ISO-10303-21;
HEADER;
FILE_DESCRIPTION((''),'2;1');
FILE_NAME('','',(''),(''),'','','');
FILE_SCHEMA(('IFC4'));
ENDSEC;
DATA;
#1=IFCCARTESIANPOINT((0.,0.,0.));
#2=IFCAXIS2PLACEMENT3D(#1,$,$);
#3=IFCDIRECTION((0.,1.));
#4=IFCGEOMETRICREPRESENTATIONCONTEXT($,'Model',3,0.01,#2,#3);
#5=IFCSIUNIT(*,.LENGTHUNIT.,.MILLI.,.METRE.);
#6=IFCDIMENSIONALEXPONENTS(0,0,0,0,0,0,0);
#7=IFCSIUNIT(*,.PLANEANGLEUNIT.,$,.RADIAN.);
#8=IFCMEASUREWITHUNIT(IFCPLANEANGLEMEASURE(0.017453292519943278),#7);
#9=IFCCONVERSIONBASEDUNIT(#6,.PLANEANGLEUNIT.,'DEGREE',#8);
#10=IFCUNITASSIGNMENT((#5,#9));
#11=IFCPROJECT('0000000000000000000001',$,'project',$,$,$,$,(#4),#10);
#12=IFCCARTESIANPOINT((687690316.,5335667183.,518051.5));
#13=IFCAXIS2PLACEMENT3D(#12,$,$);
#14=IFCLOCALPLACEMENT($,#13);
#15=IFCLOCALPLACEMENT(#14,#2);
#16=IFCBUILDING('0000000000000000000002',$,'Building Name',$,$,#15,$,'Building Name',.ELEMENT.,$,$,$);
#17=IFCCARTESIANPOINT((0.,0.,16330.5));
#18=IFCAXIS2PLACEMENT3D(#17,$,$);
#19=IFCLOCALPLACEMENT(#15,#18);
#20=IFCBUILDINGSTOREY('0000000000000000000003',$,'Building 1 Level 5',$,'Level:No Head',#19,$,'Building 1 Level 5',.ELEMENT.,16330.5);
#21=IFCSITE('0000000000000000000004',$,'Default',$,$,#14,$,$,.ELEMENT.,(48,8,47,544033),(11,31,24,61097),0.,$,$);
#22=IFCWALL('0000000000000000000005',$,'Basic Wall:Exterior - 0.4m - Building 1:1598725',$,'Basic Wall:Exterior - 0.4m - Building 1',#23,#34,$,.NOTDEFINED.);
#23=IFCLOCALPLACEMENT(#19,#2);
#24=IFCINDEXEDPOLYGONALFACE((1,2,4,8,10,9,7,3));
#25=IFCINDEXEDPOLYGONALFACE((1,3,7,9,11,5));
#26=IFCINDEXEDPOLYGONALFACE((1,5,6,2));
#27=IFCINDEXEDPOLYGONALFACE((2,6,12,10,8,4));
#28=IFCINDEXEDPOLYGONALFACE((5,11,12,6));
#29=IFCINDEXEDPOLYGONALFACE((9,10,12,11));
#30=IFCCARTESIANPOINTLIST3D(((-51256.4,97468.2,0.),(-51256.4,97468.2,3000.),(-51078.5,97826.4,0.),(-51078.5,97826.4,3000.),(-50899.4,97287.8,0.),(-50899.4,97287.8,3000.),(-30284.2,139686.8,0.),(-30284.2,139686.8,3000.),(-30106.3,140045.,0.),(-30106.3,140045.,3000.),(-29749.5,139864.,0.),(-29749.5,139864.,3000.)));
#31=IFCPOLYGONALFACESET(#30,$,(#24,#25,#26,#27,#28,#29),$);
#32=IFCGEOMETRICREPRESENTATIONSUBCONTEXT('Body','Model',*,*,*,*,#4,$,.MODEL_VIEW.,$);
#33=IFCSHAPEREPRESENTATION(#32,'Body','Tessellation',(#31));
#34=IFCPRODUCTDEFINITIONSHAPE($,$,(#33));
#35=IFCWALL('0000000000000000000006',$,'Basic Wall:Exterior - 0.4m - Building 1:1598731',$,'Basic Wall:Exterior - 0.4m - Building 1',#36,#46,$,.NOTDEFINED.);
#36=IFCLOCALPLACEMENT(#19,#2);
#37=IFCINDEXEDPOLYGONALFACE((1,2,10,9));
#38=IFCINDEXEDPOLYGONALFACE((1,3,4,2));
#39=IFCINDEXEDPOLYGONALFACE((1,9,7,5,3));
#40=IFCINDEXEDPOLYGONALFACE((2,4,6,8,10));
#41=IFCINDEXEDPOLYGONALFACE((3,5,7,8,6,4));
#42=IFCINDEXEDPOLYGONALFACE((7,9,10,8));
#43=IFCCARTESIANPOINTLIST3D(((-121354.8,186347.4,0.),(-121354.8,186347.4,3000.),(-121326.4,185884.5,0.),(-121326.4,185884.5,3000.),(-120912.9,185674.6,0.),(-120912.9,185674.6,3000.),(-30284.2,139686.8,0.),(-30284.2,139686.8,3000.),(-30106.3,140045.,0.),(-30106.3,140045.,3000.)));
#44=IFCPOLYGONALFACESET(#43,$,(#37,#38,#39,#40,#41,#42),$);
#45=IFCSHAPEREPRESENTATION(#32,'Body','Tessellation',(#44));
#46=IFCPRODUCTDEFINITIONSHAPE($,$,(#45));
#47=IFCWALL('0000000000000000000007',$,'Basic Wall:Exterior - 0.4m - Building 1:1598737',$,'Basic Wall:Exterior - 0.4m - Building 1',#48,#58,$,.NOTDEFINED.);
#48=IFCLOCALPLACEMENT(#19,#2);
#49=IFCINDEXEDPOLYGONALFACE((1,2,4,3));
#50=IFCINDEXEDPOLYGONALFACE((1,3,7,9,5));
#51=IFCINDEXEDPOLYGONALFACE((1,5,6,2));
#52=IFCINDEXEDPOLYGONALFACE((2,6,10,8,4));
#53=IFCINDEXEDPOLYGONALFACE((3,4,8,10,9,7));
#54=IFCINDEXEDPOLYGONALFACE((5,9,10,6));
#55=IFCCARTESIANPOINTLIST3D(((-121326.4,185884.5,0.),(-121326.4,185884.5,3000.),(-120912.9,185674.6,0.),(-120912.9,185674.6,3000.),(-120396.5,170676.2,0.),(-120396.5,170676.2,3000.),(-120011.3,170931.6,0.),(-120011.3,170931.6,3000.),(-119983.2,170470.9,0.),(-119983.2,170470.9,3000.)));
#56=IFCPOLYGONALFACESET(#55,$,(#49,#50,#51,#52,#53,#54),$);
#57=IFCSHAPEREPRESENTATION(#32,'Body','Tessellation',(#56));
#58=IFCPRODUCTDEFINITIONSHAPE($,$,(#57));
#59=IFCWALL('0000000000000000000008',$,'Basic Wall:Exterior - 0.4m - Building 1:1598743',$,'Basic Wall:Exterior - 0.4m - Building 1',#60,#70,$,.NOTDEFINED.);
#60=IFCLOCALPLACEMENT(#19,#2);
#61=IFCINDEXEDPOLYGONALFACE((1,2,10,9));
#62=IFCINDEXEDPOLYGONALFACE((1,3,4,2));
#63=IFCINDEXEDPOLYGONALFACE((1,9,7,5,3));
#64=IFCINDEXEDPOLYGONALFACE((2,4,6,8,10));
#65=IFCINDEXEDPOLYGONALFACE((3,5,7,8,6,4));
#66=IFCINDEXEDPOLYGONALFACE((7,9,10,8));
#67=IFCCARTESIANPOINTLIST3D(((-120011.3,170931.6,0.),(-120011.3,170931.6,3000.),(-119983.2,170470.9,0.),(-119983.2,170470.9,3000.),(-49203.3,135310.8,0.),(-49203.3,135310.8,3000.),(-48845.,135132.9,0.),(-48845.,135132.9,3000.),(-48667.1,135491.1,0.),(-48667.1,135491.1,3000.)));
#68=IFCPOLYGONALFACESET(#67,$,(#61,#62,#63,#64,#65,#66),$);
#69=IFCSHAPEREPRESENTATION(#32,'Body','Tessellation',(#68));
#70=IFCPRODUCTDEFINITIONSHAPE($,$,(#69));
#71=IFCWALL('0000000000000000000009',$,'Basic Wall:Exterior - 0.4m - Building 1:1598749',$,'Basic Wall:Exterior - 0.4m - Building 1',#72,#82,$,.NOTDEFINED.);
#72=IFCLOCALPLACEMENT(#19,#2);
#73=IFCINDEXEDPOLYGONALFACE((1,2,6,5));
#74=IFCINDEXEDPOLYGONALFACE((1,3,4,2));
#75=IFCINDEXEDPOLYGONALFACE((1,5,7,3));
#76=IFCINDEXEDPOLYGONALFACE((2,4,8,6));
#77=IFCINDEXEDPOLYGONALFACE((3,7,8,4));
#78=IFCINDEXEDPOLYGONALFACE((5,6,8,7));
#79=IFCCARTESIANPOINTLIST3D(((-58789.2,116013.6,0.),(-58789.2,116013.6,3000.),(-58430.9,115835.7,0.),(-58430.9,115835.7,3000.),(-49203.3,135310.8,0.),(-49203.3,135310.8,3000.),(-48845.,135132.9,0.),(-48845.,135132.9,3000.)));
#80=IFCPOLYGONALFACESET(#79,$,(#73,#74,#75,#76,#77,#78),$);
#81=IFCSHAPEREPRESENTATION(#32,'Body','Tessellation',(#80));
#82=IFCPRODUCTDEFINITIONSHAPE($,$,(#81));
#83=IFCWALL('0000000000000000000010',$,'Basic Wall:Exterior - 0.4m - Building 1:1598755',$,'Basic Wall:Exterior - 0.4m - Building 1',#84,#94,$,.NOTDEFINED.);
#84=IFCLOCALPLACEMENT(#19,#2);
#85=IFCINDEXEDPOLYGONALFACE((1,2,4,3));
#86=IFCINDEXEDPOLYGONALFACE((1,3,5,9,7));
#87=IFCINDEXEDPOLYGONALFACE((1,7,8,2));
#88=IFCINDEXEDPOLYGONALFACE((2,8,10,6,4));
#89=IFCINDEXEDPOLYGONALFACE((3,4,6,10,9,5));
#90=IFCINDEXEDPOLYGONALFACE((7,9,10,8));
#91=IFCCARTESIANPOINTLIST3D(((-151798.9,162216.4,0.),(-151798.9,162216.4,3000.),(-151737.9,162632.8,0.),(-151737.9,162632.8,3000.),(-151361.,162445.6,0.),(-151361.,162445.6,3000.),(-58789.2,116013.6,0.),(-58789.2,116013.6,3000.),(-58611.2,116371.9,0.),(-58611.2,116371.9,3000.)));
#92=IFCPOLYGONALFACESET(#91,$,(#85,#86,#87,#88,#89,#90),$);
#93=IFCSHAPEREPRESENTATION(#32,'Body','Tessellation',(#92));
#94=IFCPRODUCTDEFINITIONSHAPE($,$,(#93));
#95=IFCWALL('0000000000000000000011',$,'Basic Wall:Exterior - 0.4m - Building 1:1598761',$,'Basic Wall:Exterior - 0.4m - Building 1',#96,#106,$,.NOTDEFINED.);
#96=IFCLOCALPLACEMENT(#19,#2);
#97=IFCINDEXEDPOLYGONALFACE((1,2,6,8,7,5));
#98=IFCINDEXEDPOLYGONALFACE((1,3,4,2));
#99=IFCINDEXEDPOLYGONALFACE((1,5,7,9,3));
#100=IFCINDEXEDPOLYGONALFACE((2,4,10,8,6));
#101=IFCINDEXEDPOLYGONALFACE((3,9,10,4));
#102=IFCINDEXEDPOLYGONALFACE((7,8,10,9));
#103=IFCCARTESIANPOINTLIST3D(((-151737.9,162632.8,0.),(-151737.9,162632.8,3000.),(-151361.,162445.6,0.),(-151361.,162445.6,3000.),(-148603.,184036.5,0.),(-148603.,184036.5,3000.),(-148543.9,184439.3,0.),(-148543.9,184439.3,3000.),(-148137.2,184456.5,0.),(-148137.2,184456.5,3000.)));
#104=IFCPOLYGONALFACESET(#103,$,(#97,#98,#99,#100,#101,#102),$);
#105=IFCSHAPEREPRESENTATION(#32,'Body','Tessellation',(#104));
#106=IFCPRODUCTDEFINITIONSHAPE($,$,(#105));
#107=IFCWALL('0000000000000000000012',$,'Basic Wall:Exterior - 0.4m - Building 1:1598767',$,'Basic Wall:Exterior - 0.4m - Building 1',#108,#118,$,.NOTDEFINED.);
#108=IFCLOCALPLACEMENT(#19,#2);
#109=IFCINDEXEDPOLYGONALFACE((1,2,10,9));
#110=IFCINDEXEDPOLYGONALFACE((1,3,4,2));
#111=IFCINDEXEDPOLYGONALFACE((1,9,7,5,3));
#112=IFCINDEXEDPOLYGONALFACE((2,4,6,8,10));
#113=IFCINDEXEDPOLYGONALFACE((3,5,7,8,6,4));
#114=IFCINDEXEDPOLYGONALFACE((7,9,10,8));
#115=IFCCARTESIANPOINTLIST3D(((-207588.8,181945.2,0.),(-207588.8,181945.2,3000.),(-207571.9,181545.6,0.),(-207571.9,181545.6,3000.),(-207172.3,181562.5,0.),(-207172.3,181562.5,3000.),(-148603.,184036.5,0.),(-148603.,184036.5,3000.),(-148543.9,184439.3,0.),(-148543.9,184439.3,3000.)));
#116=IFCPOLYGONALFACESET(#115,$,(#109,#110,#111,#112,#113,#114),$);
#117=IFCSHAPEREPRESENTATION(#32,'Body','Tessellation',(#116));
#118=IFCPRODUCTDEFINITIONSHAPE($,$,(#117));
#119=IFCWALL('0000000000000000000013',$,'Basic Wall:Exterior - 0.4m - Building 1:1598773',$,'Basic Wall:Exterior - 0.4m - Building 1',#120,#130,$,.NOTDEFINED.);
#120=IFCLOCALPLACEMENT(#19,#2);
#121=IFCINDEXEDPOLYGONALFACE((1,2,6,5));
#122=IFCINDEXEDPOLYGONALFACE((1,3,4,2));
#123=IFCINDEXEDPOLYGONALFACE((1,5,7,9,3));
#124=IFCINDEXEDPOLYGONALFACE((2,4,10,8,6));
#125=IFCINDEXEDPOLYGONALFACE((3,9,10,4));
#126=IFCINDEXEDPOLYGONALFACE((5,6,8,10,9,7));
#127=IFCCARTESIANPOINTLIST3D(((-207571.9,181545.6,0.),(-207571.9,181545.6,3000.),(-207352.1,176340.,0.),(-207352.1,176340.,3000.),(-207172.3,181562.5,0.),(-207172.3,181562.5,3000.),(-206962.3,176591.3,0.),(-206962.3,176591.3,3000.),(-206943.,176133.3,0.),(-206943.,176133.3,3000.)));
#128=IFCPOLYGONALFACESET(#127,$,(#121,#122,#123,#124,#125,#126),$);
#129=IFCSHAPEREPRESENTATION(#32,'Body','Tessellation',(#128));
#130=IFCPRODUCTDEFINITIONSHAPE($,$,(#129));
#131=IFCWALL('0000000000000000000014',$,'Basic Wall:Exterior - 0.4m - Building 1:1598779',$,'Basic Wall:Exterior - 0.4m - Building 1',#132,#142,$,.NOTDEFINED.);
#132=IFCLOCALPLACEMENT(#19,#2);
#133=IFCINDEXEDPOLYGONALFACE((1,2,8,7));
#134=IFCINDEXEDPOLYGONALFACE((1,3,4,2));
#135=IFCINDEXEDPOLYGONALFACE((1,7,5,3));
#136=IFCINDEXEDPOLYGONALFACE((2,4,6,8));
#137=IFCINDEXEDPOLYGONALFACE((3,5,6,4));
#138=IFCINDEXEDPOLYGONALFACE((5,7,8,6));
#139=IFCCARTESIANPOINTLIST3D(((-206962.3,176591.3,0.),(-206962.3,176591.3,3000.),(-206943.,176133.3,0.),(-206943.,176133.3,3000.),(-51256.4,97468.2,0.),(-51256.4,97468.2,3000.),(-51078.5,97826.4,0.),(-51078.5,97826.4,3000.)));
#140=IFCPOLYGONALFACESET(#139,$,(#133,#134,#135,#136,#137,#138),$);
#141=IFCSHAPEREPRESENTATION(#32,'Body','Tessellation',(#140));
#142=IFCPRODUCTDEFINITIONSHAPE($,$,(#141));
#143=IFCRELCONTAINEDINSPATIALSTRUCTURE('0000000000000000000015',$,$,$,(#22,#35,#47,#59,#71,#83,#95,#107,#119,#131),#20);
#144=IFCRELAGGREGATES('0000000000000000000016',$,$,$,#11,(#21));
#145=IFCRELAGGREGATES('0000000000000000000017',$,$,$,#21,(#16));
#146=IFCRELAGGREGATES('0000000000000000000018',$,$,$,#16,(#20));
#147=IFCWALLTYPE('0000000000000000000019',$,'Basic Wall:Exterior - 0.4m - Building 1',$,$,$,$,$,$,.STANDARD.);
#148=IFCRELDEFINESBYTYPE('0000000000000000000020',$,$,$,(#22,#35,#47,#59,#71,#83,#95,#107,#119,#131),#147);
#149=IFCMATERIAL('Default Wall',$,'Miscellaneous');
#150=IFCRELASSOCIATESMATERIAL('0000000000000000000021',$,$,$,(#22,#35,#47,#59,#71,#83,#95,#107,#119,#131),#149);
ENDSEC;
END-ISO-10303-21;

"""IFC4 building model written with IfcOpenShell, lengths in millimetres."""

from ifc_helpers import new_model, entity, si_unit, converted_unit, direction, frame, origin, place, context, subcontext, project, spatial, indexed_curve, outline, extrude, material, type_object, element, save


model = new_model("IFC4")

# Units and contexts
model_context = context("Model", 3, precision=0.01, world=origin(), true_north=direction((0.0, 1.0)))
body_context = subcontext(model_context, "Body", "Model", "MODEL_VIEW")
ifc_project = project(units=[si_unit("LENGTHUNIT", "METRE", prefix="MILLI"), converted_unit("PLANEANGLEUNIT", "DEGREE", entity("IfcPlaneAngleMeasure", 0.017453292519943278), si_unit("PLANEANGLEUNIT", "RADIAN"), dimensions=[0, 0, 0, 0, 0, 0, 0])], contexts=[model_context])

# Site, building, storey
site_placement = place(None, frame((687690316.0, 5335667183.0, 518051.5)))
site = spatial("IfcSite", under=ifc_project, at=site_placement, Name="Default", CompositionType="ELEMENT", RefLatitude=(48, 8, 47, 544033), RefLongitude=(11, 31, 24, 61097), RefElevation=0.0)
building_placement = place(site_placement, origin())
building = spatial("IfcBuilding", under=site, at=building_placement, Name="Building Name", LongName="Building Name", CompositionType="ELEMENT")
storey_placement = place(building_placement, frame((0.0, 0.0, 16330.5)))
storey = spatial("IfcBuildingStorey", under=building, at=storey_placement, Name="Building 1 Level 5", ObjectType="Level:No Head", LongName="Building 1 Level 5", CompositionType="ELEMENT", Elevation=16330.5)

# Walls
ifc_material_1 = material(Name="Default Wall", Category="Miscellaneous")
wall_type = type_object("IfcWallType", Name="Basic Wall:Exterior - 0.4m - Building 1", PredefinedType="STANDARD")
wall_1_placement = place(storey_placement, frame((-51078.5, 97376.7, 0.0), z_axis=(0.0, 0.0, 1.0), x_axis=(0.444885, 0.895588, 0.0)))
element("IfcWall", 1, at=wall_1_placement, inside=storey, type_object=wall_type, material=ifc_material_1, Name="Basic Wall:Exterior - 0.4m - Building 1:1598725", ObjectType="Basic Wall:Exterior - 0.4m - Building 1", PredefinedType="NOTDEFINED", context=body_context, shape_type="SweptSolid", body=[
    extrude(outline(indexed_curve([(47540.0, -200.0), (47543.5, 200.0), (47143.4, 200.0), (402.7, 200.0), (2.7, 200.0), (0.0, -200.0), (47540.0, -200.0)], self_intersect=False)), origin(), (0.0, 0.0, 1.0), 3000.0),
])
wall_2_placement = place(storey_placement, frame((-30193.7, 139865.1, 0.0), z_axis=(0.0, 0.0, 1.0), x_axis=(-0.891761, 0.452507, 0.0)))
element("IfcWall", 2, at=wall_2_placement, inside=storey, type_object=wall_type, material=ifc_material_1, Name="Basic Wall:Exterior - 0.4m - Building 1:1598731", ObjectType="Basic Wall:Exterior - 0.4m - Building 1", PredefinedType="NOTDEFINED", context=body_context, shape_type="SweptSolid", body=[
    extrude(outline(indexed_curve([(102327.4, -200.0), (102092.7, 200.0), (101628.9, 200.0), (0.0, 200.0), (3.4, -200.0), (102327.4, -200.0)], self_intersect=False)), origin(), (0.0, 0.0, 1.0), 3000.0),
])
wall_3_placement = place(storey_placement, frame((-121126.8, 185896.7, 0.0), z_axis=(0.0, 0.0, 1.0), x_axis=(0.061037, -0.998136, 0.0)))
element("IfcWall", 3, at=wall_3_placement, inside=storey, type_object=wall_type, material=ifc_material_1, Name="Basic Wall:Exterior - 0.4m - Building 1:1598737", ObjectType="Basic Wall:Exterior - 0.4m - Building 1", PredefinedType="NOTDEFINED", context=body_context, shape_type="SweptSolid", body=[
    extrude(outline(indexed_curve([(15236.7, -200.0), (15466.8, 200.0), (15005.3, 200.0), (234.7, 200.0), (0.0, -200.0), (15236.7, -200.0)], self_intersect=False)), origin(), (0.0, 0.0, 1.0), 3000.0),
])
wall_4_placement = place(storey_placement, frame((-120100.3, 170752.4, 0.0), z_axis=(0.0, 0.0, 1.0), x_axis=(0.895588, -0.444885, 0.0)))
element("IfcWall", 4, at=wall_4_placement, inside=storey, type_object=wall_type, material=ifc_material_1, Name="Basic Wall:Exterior - 0.4m - Building 1:1598743", ObjectType="Basic Wall:Exterior - 0.4m - Building 1", PredefinedType="NOTDEFINED", context=body_context, shape_type="SweptSolid", body=[
    extrude(outline(indexed_curve([(79662.0, -200.0), (79662.0, 200.0), (0.0, 200.0), (230.2, -200.0), (79262.0, -200.0), (79662.0, -200.0)], self_intersect=False)), origin(), (0.0, 0.0, 1.0), 3000.0),
])
wall_5_placement = place(storey_placement, frame((-49024.1, 135221.9, 0.0), z_axis=(0.0, 0.0, 1.0), x_axis=(-0.444885, -0.895588, 0.0)))
element("IfcWall", 5, at=wall_5_placement, inside=storey, type_object=wall_type, material=ifc_material_1, Name="Basic Wall:Exterior - 0.4m - Building 1:1598749", ObjectType="Basic Wall:Exterior - 0.4m - Building 1", PredefinedType="NOTDEFINED", context=body_context, shape_type="SweptSolid", body=[
    extrude(outline(indexed_curve([(21547.0, 200.0), (0.0, 200.0), (0.0, -200.0), (21547.0, -200.0), (21547.0, 200.0)], self_intersect=False)), origin(), (0.0, 0.0, 1.0), 3000.0),
])
wall_6_placement = place(storey_placement, frame((-58700.2, 116192.8, 0.0), z_axis=(0.0, 0.0, 1.0), x_axis=(-0.895588, 0.444885, 0.0)))
element("IfcWall", 6, at=wall_6_placement, inside=storey, type_object=wall_type, material=ifc_material_1, Name="Basic Wall:Exterior - 0.4m - Building 1:1598755", ObjectType="Basic Wall:Exterior - 0.4m - Building 1", PredefinedType="NOTDEFINED", context=body_context, shape_type="SweptSolid", body=[
    extrude(outline(indexed_curve([(103983.9, -200.0), (103853.3, 200.0), (0.0, 200.0), (0.0, -200.0), (103563.1, -200.0), (103983.9, -200.0)], self_intersect=False)), origin(), (0.0, 0.0, 1.0), 3000.0),
])
wall_7_placement = place(storey_placement, frame((-151558.9, 162474.6, 0.0), z_axis=(0.0, 0.0, 1.0), x_axis=(0.144921, 0.989443, 0.0)))
element("IfcWall", 7, at=wall_7_placement, inside=storey, type_object=wall_type, material=ifc_material_1, Name="Basic Wall:Exterior - 0.4m - Building 1:1598761", ObjectType="Basic Wall:Exterior - 0.4m - Building 1", PredefinedType="NOTDEFINED", context=body_context, shape_type="SweptSolid", body=[
    extrude(outline(indexed_curve([(22245.8, -200.0), (22169.8, 200.0), (21762.7, 200.0), (130.6, 200.0), (0.0, -200.0), (22245.8, -200.0)], self_intersect=False)), origin(), (0.0, 0.0, 1.0), 3000.0),
])
wall_8_placement = place(storey_placement, frame((-148535.5, 184239.5, 0.0), z_axis=(0.0, 0.0, 1.0), x_axis=(-0.999109, -0.042203, 0.0)))
element("IfcWall", 8, at=wall_8_placement, inside=storey, type_object=wall_type, material=ifc_material_1, Name="Basic Wall:Exterior - 0.4m - Building 1:1598767", ObjectType="Basic Wall:Exterior - 0.4m - Building 1", PredefinedType="NOTDEFINED", context=body_context, shape_type="SweptSolid", body=[
    extrude(outline(indexed_curve([(59097.5, -200.0), (59097.5, 200.0), (58697.5, 200.0), (76.0, 200.0), (0.0, -200.0), (59097.5, -200.0)], self_intersect=False)), origin(), (0.0, 0.0, 1.0), 3000.0),
])
wall_9_placement = place(storey_placement, frame((-207372.1, 181554.0, 0.0), z_axis=(0.0, 0.0, 1.0), x_axis=(0.042203, -0.999109, 0.0)))
element("IfcWall", 9, at=wall_9_placement, inside=storey, type_object=wall_type, material=ifc_material_1, Name="Basic Wall:Exterior - 0.4m - Building 1:1598773", ObjectType="Basic Wall:Exterior - 0.4m - Building 1", PredefinedType="NOTDEFINED", context=body_context, shape_type="SweptSolid", body=[
    extrude(outline(indexed_curve([(5210.2, -200.0), (5434.0, 200.0), (4975.6, 200.0), (0.0, 200.0), (0.0, -200.0), (5210.2, -200.0)], self_intersect=False)), origin(), (0.0, 0.0, 1.0), 3000.0),
])
wall_10_placement = place(storey_placement, frame((-207052.5, 176412.8, 0.0), z_axis=(0.0, 0.0, 1.0), x_axis=(0.892534, -0.450979, 0.0)))
element("IfcWall", 10, at=wall_10_placement, inside=storey, type_object=wall_type, material=ifc_material_1, Name="Basic Wall:Exterior - 0.4m - Building 1:1598779", ObjectType="Basic Wall:Exterior - 0.4m - Building 1", PredefinedType="NOTDEFINED", context=body_context, shape_type="SweptSolid", body=[
    extrude(outline(indexed_curve([(174655.7, -200.0), (174653.0, 200.0), (0.0, 200.0), (223.8, -200.0), (174655.7, -200.0)], self_intersect=False)), origin(), (0.0, 0.0, 1.0), 3000.0),
])

save(model, "model.ifc")
